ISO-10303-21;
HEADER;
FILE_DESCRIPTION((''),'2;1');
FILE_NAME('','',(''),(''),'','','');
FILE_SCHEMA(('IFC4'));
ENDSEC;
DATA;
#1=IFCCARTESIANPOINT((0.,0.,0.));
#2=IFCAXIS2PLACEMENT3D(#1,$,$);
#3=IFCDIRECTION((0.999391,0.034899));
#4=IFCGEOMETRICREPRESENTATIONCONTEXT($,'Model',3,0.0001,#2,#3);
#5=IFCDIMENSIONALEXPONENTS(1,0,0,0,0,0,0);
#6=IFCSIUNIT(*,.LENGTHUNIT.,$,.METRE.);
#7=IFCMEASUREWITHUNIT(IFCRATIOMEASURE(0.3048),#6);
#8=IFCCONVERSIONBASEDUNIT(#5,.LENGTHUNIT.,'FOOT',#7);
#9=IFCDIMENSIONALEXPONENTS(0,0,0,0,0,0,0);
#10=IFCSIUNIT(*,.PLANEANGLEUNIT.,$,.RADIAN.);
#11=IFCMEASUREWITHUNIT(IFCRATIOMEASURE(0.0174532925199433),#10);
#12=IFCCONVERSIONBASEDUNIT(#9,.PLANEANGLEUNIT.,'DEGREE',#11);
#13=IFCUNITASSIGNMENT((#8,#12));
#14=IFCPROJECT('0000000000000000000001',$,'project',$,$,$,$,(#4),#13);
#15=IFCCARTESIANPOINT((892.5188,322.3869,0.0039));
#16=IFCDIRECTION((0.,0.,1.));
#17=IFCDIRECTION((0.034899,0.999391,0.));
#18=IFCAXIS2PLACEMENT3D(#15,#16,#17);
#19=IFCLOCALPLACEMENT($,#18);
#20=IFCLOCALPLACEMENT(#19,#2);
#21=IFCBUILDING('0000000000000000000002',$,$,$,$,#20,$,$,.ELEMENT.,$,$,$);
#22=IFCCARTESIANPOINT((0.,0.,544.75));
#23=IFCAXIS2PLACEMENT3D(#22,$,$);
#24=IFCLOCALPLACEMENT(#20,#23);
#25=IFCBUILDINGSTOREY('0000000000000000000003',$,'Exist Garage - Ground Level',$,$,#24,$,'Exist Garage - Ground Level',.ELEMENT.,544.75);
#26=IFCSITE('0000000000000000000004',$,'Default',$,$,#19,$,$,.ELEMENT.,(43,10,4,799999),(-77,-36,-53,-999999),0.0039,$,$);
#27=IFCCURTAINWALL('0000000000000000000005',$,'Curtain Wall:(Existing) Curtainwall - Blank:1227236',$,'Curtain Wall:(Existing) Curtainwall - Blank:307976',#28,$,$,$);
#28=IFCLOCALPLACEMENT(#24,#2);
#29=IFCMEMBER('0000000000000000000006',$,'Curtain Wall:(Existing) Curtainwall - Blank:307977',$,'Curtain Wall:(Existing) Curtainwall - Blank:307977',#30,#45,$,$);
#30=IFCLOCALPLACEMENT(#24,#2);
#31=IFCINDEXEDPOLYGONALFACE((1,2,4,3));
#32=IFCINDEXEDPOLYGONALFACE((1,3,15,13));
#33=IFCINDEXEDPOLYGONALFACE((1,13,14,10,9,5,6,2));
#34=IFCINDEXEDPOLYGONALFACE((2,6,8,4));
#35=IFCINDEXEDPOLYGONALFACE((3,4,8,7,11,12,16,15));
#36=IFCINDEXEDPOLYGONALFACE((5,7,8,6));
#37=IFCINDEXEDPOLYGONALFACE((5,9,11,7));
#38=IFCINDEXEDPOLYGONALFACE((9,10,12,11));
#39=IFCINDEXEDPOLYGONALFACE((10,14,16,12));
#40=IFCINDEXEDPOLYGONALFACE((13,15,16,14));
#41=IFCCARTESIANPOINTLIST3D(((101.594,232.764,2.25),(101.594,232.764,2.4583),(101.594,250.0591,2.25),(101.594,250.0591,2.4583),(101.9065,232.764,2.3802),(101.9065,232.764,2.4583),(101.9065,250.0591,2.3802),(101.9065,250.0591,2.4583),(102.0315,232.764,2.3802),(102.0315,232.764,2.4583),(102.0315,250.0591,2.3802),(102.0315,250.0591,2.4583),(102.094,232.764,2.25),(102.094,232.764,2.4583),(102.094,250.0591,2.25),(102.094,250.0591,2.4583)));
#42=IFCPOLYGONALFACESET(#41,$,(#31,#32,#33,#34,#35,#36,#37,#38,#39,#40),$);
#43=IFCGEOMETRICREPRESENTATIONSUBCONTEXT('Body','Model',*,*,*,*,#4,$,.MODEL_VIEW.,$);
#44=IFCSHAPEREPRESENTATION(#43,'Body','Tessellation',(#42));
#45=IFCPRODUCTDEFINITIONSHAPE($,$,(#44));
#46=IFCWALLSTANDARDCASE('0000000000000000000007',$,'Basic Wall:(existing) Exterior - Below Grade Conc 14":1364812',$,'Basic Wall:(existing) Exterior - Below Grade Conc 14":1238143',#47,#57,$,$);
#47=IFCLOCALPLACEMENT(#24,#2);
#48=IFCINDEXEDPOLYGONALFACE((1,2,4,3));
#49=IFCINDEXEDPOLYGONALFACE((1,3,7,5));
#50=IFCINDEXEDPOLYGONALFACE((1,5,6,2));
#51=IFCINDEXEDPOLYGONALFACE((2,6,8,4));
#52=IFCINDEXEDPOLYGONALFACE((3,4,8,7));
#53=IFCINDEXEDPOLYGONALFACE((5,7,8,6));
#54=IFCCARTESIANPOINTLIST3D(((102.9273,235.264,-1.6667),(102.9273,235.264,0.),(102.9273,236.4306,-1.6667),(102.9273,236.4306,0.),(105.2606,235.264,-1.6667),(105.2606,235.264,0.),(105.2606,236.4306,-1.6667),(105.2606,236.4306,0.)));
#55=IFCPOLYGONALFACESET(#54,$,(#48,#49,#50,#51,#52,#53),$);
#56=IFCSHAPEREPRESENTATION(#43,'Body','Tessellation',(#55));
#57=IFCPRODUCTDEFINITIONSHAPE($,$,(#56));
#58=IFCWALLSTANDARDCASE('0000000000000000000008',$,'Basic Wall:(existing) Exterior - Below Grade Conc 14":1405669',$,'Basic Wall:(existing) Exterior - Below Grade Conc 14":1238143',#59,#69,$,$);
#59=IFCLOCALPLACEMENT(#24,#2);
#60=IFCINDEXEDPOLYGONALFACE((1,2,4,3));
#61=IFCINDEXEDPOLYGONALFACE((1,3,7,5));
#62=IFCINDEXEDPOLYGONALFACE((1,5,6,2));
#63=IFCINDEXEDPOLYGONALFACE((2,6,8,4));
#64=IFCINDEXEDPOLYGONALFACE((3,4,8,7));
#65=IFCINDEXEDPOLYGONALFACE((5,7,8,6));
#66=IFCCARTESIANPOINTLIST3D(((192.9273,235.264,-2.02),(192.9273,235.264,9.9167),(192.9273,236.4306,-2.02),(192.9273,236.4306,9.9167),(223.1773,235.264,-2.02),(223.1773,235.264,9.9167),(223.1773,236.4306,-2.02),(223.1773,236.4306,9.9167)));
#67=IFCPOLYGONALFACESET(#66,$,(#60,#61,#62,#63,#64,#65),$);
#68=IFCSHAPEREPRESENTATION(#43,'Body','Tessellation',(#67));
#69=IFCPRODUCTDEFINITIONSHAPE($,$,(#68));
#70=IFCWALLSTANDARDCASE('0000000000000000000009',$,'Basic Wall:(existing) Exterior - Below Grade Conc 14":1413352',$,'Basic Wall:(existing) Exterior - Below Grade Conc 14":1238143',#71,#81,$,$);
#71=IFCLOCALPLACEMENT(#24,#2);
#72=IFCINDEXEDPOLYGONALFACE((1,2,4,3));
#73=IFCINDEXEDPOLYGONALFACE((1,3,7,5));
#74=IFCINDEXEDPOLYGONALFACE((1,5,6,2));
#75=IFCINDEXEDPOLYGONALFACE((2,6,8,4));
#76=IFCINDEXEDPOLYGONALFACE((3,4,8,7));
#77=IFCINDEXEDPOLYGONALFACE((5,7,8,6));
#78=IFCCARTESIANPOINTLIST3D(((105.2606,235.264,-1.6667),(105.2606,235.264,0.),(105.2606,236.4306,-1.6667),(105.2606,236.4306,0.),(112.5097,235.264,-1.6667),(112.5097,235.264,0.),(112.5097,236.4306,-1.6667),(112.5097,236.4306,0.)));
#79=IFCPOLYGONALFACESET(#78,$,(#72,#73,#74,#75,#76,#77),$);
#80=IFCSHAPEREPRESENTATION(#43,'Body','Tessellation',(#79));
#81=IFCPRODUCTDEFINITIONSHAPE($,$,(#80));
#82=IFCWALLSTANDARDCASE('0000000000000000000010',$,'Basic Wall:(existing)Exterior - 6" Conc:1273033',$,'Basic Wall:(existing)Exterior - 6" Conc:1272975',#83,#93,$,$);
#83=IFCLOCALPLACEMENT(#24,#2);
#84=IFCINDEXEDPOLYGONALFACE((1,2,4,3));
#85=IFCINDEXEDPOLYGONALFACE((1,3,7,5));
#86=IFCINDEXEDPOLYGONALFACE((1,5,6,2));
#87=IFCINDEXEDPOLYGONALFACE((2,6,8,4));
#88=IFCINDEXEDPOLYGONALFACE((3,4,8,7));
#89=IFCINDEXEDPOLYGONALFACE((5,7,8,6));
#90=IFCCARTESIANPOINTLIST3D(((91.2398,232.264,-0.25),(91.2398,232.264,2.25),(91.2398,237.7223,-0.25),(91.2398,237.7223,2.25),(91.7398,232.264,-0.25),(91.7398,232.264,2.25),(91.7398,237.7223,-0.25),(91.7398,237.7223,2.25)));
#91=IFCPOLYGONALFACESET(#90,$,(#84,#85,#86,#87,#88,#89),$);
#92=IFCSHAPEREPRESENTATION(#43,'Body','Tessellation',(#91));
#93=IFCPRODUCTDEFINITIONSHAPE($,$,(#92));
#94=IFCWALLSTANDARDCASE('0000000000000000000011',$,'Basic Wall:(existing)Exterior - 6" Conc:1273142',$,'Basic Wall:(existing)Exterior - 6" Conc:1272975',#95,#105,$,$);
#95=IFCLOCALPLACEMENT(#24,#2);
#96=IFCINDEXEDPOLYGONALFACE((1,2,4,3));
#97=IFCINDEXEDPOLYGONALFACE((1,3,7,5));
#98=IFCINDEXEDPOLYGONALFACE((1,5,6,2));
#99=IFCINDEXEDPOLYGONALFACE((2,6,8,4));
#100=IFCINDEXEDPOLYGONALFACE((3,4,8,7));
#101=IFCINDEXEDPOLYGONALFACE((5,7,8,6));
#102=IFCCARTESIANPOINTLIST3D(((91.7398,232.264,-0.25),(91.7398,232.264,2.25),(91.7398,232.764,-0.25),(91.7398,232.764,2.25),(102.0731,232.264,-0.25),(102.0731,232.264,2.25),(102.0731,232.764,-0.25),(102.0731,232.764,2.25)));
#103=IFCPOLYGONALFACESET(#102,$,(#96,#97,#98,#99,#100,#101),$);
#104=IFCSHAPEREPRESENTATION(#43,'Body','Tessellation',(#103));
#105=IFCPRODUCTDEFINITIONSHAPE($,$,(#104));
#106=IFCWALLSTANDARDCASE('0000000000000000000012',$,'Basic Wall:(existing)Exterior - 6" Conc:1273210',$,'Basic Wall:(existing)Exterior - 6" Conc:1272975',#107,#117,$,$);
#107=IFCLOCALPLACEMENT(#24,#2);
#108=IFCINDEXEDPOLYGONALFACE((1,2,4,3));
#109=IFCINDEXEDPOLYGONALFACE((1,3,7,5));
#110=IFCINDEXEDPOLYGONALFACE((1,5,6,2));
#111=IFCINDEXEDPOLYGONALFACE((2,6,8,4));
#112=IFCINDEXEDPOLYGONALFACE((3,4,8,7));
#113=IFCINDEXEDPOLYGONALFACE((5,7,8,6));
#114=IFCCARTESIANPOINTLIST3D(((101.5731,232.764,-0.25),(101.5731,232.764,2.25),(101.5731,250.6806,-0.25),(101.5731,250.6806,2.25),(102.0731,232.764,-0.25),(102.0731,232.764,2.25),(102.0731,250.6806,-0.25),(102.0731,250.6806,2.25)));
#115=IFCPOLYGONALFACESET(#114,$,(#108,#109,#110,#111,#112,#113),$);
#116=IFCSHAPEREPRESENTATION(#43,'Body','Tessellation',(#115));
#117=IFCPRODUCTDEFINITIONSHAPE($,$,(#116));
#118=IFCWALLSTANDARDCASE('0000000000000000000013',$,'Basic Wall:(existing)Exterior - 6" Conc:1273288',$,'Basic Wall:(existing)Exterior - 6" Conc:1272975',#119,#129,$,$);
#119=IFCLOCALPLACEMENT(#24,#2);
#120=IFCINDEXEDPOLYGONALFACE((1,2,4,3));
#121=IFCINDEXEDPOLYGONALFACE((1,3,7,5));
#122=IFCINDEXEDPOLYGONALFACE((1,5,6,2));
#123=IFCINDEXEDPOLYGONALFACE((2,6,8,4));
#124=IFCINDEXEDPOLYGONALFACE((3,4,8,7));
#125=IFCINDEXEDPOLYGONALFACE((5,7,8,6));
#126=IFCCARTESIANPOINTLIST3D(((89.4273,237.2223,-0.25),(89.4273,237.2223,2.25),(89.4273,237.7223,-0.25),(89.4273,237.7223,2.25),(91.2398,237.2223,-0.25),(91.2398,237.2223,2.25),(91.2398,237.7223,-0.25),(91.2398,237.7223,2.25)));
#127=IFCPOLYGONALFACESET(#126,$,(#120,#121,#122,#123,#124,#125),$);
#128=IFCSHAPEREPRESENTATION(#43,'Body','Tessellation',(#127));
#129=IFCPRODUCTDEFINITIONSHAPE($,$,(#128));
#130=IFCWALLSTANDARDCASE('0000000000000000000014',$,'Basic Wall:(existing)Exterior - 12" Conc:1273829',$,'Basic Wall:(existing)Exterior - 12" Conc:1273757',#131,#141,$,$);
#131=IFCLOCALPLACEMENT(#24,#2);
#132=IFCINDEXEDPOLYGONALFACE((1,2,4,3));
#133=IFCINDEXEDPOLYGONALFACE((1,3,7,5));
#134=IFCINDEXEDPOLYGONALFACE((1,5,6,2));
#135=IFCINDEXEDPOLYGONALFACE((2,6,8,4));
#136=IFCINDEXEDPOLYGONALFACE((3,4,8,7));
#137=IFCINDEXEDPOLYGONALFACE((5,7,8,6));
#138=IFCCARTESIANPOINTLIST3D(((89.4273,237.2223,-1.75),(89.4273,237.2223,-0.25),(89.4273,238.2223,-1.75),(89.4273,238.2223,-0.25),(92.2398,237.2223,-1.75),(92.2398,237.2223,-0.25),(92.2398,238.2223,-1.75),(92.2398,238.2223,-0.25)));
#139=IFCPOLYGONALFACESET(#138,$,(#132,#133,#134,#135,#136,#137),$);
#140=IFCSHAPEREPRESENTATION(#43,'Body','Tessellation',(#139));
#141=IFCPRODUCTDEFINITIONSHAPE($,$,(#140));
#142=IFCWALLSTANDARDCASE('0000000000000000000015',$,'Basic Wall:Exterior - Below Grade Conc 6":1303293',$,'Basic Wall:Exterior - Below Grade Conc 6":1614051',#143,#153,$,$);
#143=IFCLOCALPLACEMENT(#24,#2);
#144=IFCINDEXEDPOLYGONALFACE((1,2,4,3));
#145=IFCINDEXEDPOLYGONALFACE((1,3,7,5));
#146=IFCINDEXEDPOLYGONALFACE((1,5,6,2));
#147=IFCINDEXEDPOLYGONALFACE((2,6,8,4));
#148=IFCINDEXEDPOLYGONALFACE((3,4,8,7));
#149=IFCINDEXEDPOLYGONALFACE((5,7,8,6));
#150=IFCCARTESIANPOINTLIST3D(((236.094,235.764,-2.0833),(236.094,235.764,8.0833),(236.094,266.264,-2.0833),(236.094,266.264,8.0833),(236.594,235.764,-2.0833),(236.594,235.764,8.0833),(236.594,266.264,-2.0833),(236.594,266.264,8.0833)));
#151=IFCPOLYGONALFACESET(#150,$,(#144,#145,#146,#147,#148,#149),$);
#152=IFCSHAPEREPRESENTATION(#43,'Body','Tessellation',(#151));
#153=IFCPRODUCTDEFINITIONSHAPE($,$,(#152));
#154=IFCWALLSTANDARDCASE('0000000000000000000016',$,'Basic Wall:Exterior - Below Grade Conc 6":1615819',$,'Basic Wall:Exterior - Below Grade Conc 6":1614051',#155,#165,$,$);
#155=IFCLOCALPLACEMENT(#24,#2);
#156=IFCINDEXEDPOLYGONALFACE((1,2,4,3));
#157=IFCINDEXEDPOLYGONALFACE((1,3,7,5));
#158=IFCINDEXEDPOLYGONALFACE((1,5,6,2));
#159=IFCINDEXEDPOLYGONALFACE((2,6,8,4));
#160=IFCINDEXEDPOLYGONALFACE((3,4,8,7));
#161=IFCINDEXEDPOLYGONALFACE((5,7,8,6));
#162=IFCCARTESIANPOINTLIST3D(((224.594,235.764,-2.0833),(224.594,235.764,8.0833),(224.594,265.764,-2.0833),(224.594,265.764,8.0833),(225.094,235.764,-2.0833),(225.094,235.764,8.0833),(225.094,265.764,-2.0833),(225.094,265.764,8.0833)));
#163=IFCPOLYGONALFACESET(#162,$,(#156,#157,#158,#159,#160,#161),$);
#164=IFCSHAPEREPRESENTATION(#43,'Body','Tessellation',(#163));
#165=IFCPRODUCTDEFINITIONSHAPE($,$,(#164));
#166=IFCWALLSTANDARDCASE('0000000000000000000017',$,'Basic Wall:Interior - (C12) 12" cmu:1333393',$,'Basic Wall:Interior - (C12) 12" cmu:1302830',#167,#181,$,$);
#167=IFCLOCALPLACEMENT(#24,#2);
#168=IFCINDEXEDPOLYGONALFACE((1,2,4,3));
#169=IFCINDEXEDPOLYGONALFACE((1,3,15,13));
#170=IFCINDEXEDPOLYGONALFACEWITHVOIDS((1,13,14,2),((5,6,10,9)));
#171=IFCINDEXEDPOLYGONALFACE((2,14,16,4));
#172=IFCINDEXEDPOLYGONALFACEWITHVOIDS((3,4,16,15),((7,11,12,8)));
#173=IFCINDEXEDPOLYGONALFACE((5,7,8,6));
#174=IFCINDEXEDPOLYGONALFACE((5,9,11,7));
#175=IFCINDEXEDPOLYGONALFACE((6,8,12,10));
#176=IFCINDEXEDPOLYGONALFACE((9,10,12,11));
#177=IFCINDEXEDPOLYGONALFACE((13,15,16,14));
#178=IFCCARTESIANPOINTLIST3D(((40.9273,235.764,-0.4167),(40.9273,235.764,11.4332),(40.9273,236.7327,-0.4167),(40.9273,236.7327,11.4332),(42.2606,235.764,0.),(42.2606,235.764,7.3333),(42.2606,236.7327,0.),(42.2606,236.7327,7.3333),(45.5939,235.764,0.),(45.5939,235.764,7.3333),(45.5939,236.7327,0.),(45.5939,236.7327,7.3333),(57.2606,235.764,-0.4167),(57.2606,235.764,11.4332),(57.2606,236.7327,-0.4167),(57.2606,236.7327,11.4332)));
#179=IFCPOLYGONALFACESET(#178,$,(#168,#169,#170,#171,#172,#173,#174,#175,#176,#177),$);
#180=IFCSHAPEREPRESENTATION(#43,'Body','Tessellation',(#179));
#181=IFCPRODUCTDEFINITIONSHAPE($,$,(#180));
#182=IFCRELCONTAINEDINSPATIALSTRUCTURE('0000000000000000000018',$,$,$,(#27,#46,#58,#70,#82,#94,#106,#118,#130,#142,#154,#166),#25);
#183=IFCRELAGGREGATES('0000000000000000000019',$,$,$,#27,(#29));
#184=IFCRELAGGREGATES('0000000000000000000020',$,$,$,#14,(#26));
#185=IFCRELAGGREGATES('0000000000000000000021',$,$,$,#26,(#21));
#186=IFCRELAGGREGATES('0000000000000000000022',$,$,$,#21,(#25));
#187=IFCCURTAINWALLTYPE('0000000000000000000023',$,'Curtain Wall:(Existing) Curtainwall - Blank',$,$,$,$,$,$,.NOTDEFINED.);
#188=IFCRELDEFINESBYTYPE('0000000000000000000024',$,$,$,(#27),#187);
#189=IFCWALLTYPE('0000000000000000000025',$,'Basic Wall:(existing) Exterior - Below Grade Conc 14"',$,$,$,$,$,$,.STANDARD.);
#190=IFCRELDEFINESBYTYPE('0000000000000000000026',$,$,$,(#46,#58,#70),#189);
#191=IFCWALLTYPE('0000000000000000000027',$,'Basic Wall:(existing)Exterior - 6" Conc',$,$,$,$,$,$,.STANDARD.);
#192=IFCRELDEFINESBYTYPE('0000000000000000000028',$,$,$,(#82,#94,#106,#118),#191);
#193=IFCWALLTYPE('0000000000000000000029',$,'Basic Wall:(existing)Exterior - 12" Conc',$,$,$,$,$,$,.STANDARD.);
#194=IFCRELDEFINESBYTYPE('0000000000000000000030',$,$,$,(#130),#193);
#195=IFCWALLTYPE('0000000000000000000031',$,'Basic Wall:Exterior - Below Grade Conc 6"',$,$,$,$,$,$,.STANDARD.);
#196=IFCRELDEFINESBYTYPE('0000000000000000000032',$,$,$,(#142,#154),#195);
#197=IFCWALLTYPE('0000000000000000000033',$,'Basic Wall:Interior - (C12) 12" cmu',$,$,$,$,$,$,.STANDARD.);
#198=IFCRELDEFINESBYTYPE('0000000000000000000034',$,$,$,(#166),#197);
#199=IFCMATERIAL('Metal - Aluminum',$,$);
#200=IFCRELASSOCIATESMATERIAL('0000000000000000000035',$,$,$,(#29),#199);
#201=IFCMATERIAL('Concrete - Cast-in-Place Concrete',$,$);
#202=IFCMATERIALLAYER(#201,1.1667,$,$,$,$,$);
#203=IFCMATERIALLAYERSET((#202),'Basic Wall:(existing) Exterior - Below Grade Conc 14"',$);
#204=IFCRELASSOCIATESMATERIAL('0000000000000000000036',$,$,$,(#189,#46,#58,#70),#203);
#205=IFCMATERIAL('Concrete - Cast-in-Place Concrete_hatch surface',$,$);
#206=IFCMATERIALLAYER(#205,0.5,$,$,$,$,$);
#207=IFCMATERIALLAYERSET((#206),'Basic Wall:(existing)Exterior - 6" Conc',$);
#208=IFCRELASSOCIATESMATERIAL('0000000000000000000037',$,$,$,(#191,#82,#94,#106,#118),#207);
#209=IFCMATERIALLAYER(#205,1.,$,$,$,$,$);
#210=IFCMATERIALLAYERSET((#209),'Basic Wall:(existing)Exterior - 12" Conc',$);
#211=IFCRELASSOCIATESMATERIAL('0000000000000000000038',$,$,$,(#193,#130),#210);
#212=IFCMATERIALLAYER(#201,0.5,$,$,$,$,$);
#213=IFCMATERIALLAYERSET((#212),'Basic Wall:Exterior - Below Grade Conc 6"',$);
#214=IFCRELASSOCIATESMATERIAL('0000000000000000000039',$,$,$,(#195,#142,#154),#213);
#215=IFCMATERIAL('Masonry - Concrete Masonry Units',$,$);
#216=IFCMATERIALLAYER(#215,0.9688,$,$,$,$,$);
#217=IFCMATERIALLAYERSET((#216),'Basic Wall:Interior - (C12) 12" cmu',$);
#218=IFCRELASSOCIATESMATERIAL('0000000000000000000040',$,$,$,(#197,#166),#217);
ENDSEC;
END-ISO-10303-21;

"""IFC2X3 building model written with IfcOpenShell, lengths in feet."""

from ifc_helpers import new_model, entity, si_unit, converted_unit, direction, frame, frame_2d, origin, place, context, subcontext, project, spatial, polyline, rectangle, outline, extrude, material, layer, layer_set, layer_usage, type_object, element, aggregate, save


model = new_model("IFC2X3")

# Units and contexts
model_context = context("Model", 3, precision=0.0001, world=origin(), true_north=direction((0.999391, 0.034899)))
body_context = subcontext(model_context, "Body", "Model", "MODEL_VIEW")
ifc_project = project(units=[converted_unit("LENGTHUNIT", "FOOT", entity("IfcRatioMeasure", 0.3048), si_unit("LENGTHUNIT", "METRE"), dimensions=[1, 0, 0, 0, 0, 0, 0]), converted_unit("PLANEANGLEUNIT", "DEGREE", entity("IfcRatioMeasure", 0.0174532925199433), si_unit("PLANEANGLEUNIT", "RADIAN"), dimensions=[0, 0, 0, 0, 0, 0, 0])], contexts=[model_context])

# Site, building, storey
site_placement = place(None, frame((892.5188, 322.3869, 0.0039), z_axis=(0.0, 0.0, 1.0), x_axis=(0.034899, 0.999391, 0.0)))
site = spatial("IfcSite", under=ifc_project, at=site_placement, Name="Default", CompositionType="ELEMENT", RefLatitude=(43, 10, 4, 799999), RefLongitude=(-77, -36, -53, -999999), RefElevation=0.0039)
building_placement = place(site_placement, origin())
building = spatial("IfcBuilding", under=site, at=building_placement, CompositionType="ELEMENT")
storey_placement = place(building_placement, frame((0.0, 0.0, 544.75)))
storey = spatial("IfcBuildingStorey", under=building, at=storey_placement, Name="Exist Garage - Ground Level", LongName="Exist Garage - Ground Level", CompositionType="ELEMENT", Elevation=544.75)

# Curtain wall, member
curtain_wall_type = type_object("IfcCurtainWallType", Name="Curtain Wall:(Existing) Curtainwall - Blank", PredefinedType="NOTDEFINED")
curtain_wall_placement = place(storey_placement, frame((0.0, 0.0, -544.75)))
curtain_wall = element("IfcCurtainWall", 1, at=curtain_wall_placement, inside=storey, type_object=curtain_wall_type, Name="Curtain Wall:(Existing) Curtainwall - Blank:1227236", ObjectType="Curtain Wall:(Existing) Curtainwall - Blank:307976")
ifc_material_1 = material(Name="Metal - Aluminum")
member_placement = place(curtain_wall_placement, frame((0.0, 0.0, 544.75)))
member = element("IfcMember", 2, at=member_placement, material=ifc_material_1, Name="Curtain Wall:(Existing) Curtainwall - Blank:307977", ObjectType="Curtain Wall:(Existing) Curtainwall - Blank:307977", context=body_context, shape_type="SweptSolid", body=[
    extrude(outline(polyline([(-0.0716, -0.3125), (0.1367, -0.3125), (0.1367, 0.1875), (-0.0716, 0.1875), (-0.0716, 0.125), (0.0065, 0.125), (0.0065, 0.0), (-0.0716, 0.0), (-0.0716, -0.3125)])), frame((101.9065, 250.0591, 2.3867), z_axis=(0.0, -1.0, 0.0), x_axis=(0.0, 0.0, -1.0)), (0.0, 0.0, 1.0), 17.2951),
])
aggregate(curtain_wall, [member])

# Shared definitions
ifc_material_2 = material(Name="Concrete - Cast-in-Place Concrete_hatch surface")

# Walls
ifc_material_3 = material(Name="Concrete - Cast-in-Place Concrete")
ifc_layer_1 = layer(ifc_material_3, 1.1667)
ifc_layer_set_1 = layer_set([ifc_layer_1], Name="Basic Wall:(existing) Exterior - Below Grade Conc 14\"")
ifc_layer_usage_1 = layer_usage(ifc_layer_set_1, "AXIS2", "POSITIVE", -0.5833)
wall_type_1 = type_object("IfcWallType", Name="Basic Wall:(existing) Exterior - Below Grade Conc 14\"", PredefinedType="STANDARD", material=ifc_layer_set_1)
wall_1_placement = place(storey_placement, frame((102.9273, 235.8473, -1.6667)))
element("IfcWallStandardCase", 3, at=wall_1_placement, inside=storey, type_object=wall_type_1, material=ifc_layer_usage_1, Name="Basic Wall:(existing) Exterior - Below Grade Conc 14\":1364812", ObjectType="Basic Wall:(existing) Exterior - Below Grade Conc 14\":1238143", context=body_context, shape_type="SweptSolid", body=[
    extrude(rectangle(XDim=2.3333, YDim=1.1667, at=frame_2d((1.1667, 0.0), x_axis=(-1.0, 0.0))), origin(), (0.0, 0.0, 1.0), 1.6667),
])
ifc_layer_usage_2 = layer_usage(ifc_layer_set_1, "AXIS2", "NEGATIVE", 0.5833)
wall_2_placement = place(storey_placement, frame((192.9273, 235.8473, -2.02)))
element("IfcWallStandardCase", 4, at=wall_2_placement, inside=storey, type_object=wall_type_1, material=ifc_layer_usage_2, Name="Basic Wall:(existing) Exterior - Below Grade Conc 14\":1405669", ObjectType="Basic Wall:(existing) Exterior - Below Grade Conc 14\":1238143", context=body_context, shape_type="SweptSolid", body=[
    extrude(rectangle(XDim=30.25, YDim=1.1667, at=frame_2d((15.125, 0.0), x_axis=(-1.0, 0.0))), origin(), (0.0, 0.0, 1.0), 11.9367),
])

# Walls
ifc_layer_usage_3 = layer_usage(ifc_layer_set_1, "AXIS2", "POSITIVE", -0.5833)
wall_3_placement = place(storey_placement, frame((105.2606, 235.8473, -1.6667)))
element("IfcWallStandardCase", 5, at=wall_3_placement, inside=storey, type_object=wall_type_1, material=ifc_layer_usage_3, Name="Basic Wall:(existing) Exterior - Below Grade Conc 14\":1413352", ObjectType="Basic Wall:(existing) Exterior - Below Grade Conc 14\":1238143", context=body_context, shape_type="SweptSolid", body=[
    extrude(rectangle(XDim=7.2491, YDim=1.1667, at=frame_2d((3.6245, 0.0), x_axis=(-1.0, 0.0))), origin(), (0.0, 0.0, 1.0), 1.6667),
])
ifc_layer_2 = layer(ifc_material_2, 0.5)
ifc_layer_set_2 = layer_set([ifc_layer_2], Name="Basic Wall:(existing)Exterior - 6\" Conc")
ifc_layer_usage_4 = layer_usage(ifc_layer_set_2, "AXIS2", "NEGATIVE", 0.25)
wall_type_2 = type_object("IfcWallType", Name="Basic Wall:(existing)Exterior - 6\" Conc", PredefinedType="STANDARD", material=ifc_layer_set_2)
wall_4_placement = place(storey_placement, frame((91.4898, 232.264, -0.25), z_axis=(0.0, 0.0, 1.0), x_axis=(0.0, 1.0, 0.0)))
element("IfcWallStandardCase", 6, at=wall_4_placement, inside=storey, type_object=wall_type_2, material=ifc_layer_usage_4, Name="Basic Wall:(existing)Exterior - 6\" Conc:1273033", ObjectType="Basic Wall:(existing)Exterior - 6\" Conc:1272975", context=body_context, shape_type="SweptSolid", body=[
    extrude(rectangle(XDim=5.4583, YDim=0.5, at=frame_2d((2.7292, 0.0), x_axis=(-1.0, 0.0))), origin(), (0.0, 0.0, 1.0), 2.5),
])
ifc_layer_usage_5 = layer_usage(ifc_layer_set_2, "AXIS2", "POSITIVE", -0.25)
wall_5_placement = place(storey_placement, frame((91.7398, 232.514, -0.25)))
element("IfcWallStandardCase", 7, at=wall_5_placement, inside=storey, type_object=wall_type_2, material=ifc_layer_usage_5, Name="Basic Wall:(existing)Exterior - 6\" Conc:1273142", ObjectType="Basic Wall:(existing)Exterior - 6\" Conc:1272975", context=body_context, shape_type="SweptSolid", body=[
    extrude(rectangle(XDim=10.3333, YDim=0.5, at=frame_2d((5.1667, 0.0), x_axis=(-1.0, 0.0))), origin(), (0.0, 0.0, 1.0), 2.5),
])
ifc_layer_usage_6 = layer_usage(ifc_layer_set_2, "AXIS2", "POSITIVE", -0.25)
wall_6_placement = place(storey_placement, frame((101.8231, 232.764, -0.25), z_axis=(0.0, 0.0, 1.0), x_axis=(0.0, 1.0, 0.0)))
element("IfcWallStandardCase", 8, at=wall_6_placement, inside=storey, type_object=wall_type_2, material=ifc_layer_usage_6, Name="Basic Wall:(existing)Exterior - 6\" Conc:1273210", ObjectType="Basic Wall:(existing)Exterior - 6\" Conc:1272975", context=body_context, shape_type="SweptSolid", body=[
    extrude(rectangle(XDim=17.9167, YDim=0.5, at=frame_2d((8.9583, 0.0), x_axis=(-1.0, 0.0))), origin(), (0.0, 0.0, 1.0), 2.5),
])
ifc_layer_usage_7 = layer_usage(ifc_layer_set_2, "AXIS2", "POSITIVE", -0.25)
wall_7_placement = place(storey_placement, frame((91.2398, 237.4723, -0.25), z_axis=(0.0, 0.0, 1.0), x_axis=(-1.0, 0.0, 0.0)))
element("IfcWallStandardCase", 9, at=wall_7_placement, inside=storey, type_object=wall_type_2, material=ifc_layer_usage_7, Name="Basic Wall:(existing)Exterior - 6\" Conc:1273288", ObjectType="Basic Wall:(existing)Exterior - 6\" Conc:1272975", context=body_context, shape_type="SweptSolid", body=[
    extrude(rectangle(XDim=1.8125, YDim=0.5, at=frame_2d((0.9063, 0.0), x_axis=(-1.0, 0.0))), origin(), (0.0, 0.0, 1.0), 2.5),
])
ifc_layer_3 = layer(ifc_material_2, 1.0)
ifc_layer_set_3 = layer_set([ifc_layer_3], Name="Basic Wall:(existing)Exterior - 12\" Conc")
ifc_layer_usage_8 = layer_usage(ifc_layer_set_3, "AXIS2", "POSITIVE", -0.5)
wall_type_3 = type_object("IfcWallType", Name="Basic Wall:(existing)Exterior - 12\" Conc", PredefinedType="STANDARD", material=ifc_layer_set_3)
wall_8_placement = place(storey_placement, frame((89.4273, 237.7223, -1.75)))
element("IfcWallStandardCase", 10, at=wall_8_placement, inside=storey, type_object=wall_type_3, material=ifc_layer_usage_8, Name="Basic Wall:(existing)Exterior - 12\" Conc:1273829", ObjectType="Basic Wall:(existing)Exterior - 12\" Conc:1273757", context=body_context, shape_type="SweptSolid", body=[
    extrude(rectangle(XDim=2.8125, YDim=1.0, at=frame_2d((1.4063, 0.0), x_axis=(-1.0, 0.0))), origin(), (0.0, 0.0, 1.0), 1.5),
])
ifc_layer_4 = layer(ifc_material_3, 0.5)
ifc_layer_set_4 = layer_set([ifc_layer_4], Name="Basic Wall:Exterior - Below Grade Conc 6\"")
ifc_layer_usage_9 = layer_usage(ifc_layer_set_4, "AXIS2", "POSITIVE", -0.25)
wall_type_4 = type_object("IfcWallType", Name="Basic Wall:Exterior - Below Grade Conc 6\"", PredefinedType="STANDARD", material=ifc_layer_set_4)
wall_9_placement = place(storey_placement, frame((236.344, 235.764, -2.0833), z_axis=(0.0, 0.0, 1.0), x_axis=(0.0, 1.0, 0.0)))
element("IfcWallStandardCase", 11, at=wall_9_placement, inside=storey, type_object=wall_type_4, material=ifc_layer_usage_9, Name="Basic Wall:Exterior - Below Grade Conc 6\":1303293", ObjectType="Basic Wall:Exterior - Below Grade Conc 6\":1614051", context=body_context, shape_type="SweptSolid", body=[
    extrude(rectangle(XDim=30.5, YDim=0.5, at=frame_2d((15.25, 0.0), x_axis=(-1.0, 0.0))), origin(), (0.0, 0.0, 1.0), 10.1667),
])
ifc_layer_usage_10 = layer_usage(ifc_layer_set_4, "AXIS2", "NEGATIVE", 0.25)
wall_10_placement = place(storey_placement, frame((224.844, 235.764, -2.0833), z_axis=(0.0, 0.0, 1.0), x_axis=(0.0, 1.0, 0.0)))
element("IfcWallStandardCase", 12, at=wall_10_placement, inside=storey, type_object=wall_type_4, material=ifc_layer_usage_10, Name="Basic Wall:Exterior - Below Grade Conc 6\":1615819", ObjectType="Basic Wall:Exterior - Below Grade Conc 6\":1614051", context=body_context, shape_type="SweptSolid", body=[
    extrude(rectangle(XDim=30.0, YDim=0.5, at=frame_2d((15.0, 0.0), x_axis=(-1.0, 0.0))), origin(), (0.0, 0.0, 1.0), 10.1667),
])

# Wall, opening
ifc_material_4 = material(Name="Masonry - Concrete Masonry Units")
ifc_layer_5 = layer(ifc_material_4, 0.9688)
ifc_layer_set_5 = layer_set([ifc_layer_5], Name="Basic Wall:Interior - (C12) 12\" cmu")
ifc_layer_usage_11 = layer_usage(ifc_layer_set_5, "AXIS2", "NEGATIVE", 0.4844)
wall_type_5 = type_object("IfcWallType", Name="Basic Wall:Interior - (C12) 12\" cmu", PredefinedType="STANDARD", material=ifc_layer_set_5)
wall_11_placement = place(storey_placement, frame((57.2606, 236.2483, -0.4167), z_axis=(0.0, 0.0, 1.0), x_axis=(-1.0, 0.0, 0.0)))
wall_11 = element("IfcWallStandardCase", 13, at=wall_11_placement, inside=storey, type_object=wall_type_5, material=ifc_layer_usage_11, Name="Basic Wall:Interior - (C12) 12\" cmu:1333393", ObjectType="Basic Wall:Interior - (C12) 12\" cmu:1302830", context=body_context, shape_type="SweptSolid", body=[
    extrude(rectangle(XDim=16.3333, YDim=0.9688, at=frame_2d((8.1667, 0.0), x_axis=(-1.0, 0.0))), origin(), (0.0, 0.0, 1.0), 11.8498),
])
opening_1_placement = place(wall_11_placement, frame((15.0, 0.4844, 0.4167)))
element("IfcOpeningElement", 14, at=opening_1_placement, cuts=wall_11, ObjectType="Opening", context=body_context, shape_type="SweptSolid", body=[
    extrude(rectangle(XDim=3.3333, YDim=7.3333, at=frame_2d((3.6667, 1.6667), x_axis=(0.0, -1.0))), frame((0.0, 0.0, 0.0), z_axis=(0.0, -1.0, 0.0), x_axis=(0.0, 0.0, 1.0)), (0.0, 0.0, 1.0), 0.9688),
])

save(model, "model.ifc")
